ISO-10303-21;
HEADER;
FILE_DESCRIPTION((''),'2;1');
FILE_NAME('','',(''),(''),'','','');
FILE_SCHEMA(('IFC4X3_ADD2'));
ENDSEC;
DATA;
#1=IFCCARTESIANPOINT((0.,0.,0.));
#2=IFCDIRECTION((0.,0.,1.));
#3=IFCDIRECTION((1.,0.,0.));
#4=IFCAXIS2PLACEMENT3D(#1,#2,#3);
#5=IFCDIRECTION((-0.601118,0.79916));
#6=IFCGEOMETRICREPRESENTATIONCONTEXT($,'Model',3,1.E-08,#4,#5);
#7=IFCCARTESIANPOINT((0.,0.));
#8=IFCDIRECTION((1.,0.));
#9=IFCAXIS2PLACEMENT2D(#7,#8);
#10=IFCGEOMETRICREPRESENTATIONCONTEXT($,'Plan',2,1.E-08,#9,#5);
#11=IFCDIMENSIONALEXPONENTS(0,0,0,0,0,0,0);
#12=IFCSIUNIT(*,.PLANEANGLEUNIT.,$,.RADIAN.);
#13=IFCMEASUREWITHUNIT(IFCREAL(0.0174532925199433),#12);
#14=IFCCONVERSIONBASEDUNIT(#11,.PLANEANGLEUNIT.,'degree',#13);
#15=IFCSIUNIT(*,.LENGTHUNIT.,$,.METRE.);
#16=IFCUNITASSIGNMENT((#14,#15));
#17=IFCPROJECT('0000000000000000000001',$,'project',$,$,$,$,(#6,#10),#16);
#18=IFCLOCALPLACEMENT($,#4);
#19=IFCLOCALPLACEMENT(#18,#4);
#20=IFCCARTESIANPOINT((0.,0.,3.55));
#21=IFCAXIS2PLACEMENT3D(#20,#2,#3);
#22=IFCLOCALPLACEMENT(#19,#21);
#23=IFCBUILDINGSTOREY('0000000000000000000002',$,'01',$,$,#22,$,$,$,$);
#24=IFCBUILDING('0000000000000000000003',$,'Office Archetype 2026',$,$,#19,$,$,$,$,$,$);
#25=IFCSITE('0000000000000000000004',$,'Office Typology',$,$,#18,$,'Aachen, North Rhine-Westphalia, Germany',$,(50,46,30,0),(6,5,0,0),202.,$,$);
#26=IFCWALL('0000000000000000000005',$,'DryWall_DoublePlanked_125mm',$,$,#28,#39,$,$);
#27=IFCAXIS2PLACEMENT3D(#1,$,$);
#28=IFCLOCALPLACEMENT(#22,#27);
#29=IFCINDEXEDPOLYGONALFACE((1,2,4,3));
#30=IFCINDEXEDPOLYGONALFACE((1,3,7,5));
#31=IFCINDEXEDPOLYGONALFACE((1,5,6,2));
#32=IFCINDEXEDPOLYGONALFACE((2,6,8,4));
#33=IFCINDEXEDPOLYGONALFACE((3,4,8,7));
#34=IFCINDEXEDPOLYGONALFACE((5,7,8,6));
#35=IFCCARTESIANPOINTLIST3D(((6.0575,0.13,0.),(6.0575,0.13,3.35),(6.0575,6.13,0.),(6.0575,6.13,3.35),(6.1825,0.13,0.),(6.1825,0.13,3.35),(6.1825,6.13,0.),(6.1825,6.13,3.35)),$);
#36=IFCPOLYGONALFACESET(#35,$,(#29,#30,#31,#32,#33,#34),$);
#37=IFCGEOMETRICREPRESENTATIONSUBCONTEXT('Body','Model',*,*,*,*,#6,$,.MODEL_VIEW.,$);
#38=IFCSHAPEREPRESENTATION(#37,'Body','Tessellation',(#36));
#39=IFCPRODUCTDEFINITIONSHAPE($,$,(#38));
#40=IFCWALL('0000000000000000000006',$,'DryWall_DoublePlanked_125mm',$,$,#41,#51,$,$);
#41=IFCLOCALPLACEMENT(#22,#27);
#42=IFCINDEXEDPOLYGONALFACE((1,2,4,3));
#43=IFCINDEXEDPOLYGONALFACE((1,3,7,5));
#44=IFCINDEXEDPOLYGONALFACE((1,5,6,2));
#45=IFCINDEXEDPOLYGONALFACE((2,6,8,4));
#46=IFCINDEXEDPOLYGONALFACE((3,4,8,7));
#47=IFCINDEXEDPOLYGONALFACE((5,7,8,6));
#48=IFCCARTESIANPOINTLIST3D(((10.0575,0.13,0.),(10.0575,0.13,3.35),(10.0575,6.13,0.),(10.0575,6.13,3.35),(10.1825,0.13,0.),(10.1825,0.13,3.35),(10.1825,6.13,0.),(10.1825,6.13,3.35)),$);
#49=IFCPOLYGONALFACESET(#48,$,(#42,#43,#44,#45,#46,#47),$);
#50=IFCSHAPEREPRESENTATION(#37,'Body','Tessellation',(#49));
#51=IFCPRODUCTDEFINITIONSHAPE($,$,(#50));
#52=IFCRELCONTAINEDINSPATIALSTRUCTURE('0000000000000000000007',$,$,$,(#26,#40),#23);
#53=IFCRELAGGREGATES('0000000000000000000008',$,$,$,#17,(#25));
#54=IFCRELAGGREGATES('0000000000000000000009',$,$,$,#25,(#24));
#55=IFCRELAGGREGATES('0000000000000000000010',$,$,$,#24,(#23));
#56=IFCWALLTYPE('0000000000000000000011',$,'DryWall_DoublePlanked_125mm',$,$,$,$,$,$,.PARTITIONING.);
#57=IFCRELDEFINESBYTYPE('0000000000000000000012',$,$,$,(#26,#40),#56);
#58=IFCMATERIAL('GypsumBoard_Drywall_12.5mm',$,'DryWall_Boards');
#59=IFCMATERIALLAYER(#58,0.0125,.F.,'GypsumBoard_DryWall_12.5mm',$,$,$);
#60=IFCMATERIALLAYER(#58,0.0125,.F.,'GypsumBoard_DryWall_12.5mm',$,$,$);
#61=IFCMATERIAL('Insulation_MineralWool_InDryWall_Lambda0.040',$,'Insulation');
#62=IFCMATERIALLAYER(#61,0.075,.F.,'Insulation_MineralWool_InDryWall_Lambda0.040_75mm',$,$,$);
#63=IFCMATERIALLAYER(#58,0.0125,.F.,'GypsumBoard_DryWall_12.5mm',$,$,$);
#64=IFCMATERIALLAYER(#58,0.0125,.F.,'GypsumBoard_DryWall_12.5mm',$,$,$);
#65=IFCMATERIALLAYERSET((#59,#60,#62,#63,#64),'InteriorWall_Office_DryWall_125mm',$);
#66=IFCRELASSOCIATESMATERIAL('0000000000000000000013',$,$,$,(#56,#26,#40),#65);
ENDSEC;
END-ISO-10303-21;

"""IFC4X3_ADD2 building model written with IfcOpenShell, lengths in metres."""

from ifc_helpers import new_model, entity, si_unit, converted_unit, direction, frame, origin_with_axes, origin_2d_with_axis, place, context, subcontext, project, spatial, line, indexed_curve, outline, extrude, material, layer, layer_set, layer_usage, type_object, element, save


model = new_model("IFC4X3_ADD2")

# Units and contexts
model_context = context("Model", 3, precision=1e-08, world=origin_with_axes(), true_north=direction((-0.601118, 0.79916)))
plan_context = context("Plan", 2, precision=1e-08, world=origin_2d_with_axis(), true_north=direction((-0.601118, 0.79916)))
body_context = subcontext(model_context, "Body", "Model", "MODEL_VIEW")
ifc_project = project(units=[converted_unit("PLANEANGLEUNIT", "degree", entity("IfcReal", 0.0174532925199433), si_unit("PLANEANGLEUNIT", "RADIAN"), dimensions=[0, 0, 0, 0, 0, 0, 0]), si_unit("LENGTHUNIT", "METRE")], contexts=[model_context, plan_context])

# Site, building, storey
site_placement = place(None, origin_with_axes())
site = spatial("IfcSite", under=ifc_project, at=site_placement, Name="Office Typology", LongName="Aachen, North Rhine-Westphalia, Germany", RefLatitude=(50, 46, 30, 0), RefLongitude=(6, 5, 0, 0), RefElevation=202.0)
building_placement = place(site_placement, origin_with_axes())
building = spatial("IfcBuilding", under=site, at=building_placement, Name="Office Archetype 2026")
storey_placement = place(building_placement, frame((0.0, 0.0, 3.55), z_axis=(0.0, 0.0, 1.0), x_axis=(1.0, 0.0, 0.0)))
storey = spatial("IfcBuildingStorey", under=building, at=storey_placement, Name="01")

# Walls
ifc_material_1 = material(Name="GypsumBoard_Drywall_12.5mm", Category="DryWall_Boards")
ifc_layer_1 = layer(ifc_material_1, 0.0125, ventilated=False, Name="GypsumBoard_DryWall_12.5mm")
ifc_layer_2 = layer(ifc_material_1, 0.0125, ventilated=False, Name="GypsumBoard_DryWall_12.5mm")
ifc_material_2 = material(Name="Insulation_MineralWool_InDryWall_Lambda0.040", Category="Insulation")
ifc_layer_3 = layer(ifc_material_2, 0.075, ventilated=False, Name="Insulation_MineralWool_InDryWall_Lambda0.040_75mm")
ifc_layer_4 = layer(ifc_material_1, 0.0125, ventilated=False, Name="GypsumBoard_DryWall_12.5mm")
ifc_layer_5 = layer(ifc_material_1, 0.0125, ventilated=False, Name="GypsumBoard_DryWall_12.5mm")
ifc_layer_set_1 = layer_set([ifc_layer_1, ifc_layer_2, ifc_layer_3, ifc_layer_4, ifc_layer_5], Name="InteriorWall_Office_DryWall_125mm")
wall_type_1 = type_object("IfcWallType", Name="DryWall_DoublePlanked_125mm", PredefinedType="PARTITIONING", material=ifc_layer_set_1)
ifc_layer_usage_1 = layer_usage(ifc_layer_set_1, "AXIS2", "POSITIVE", 0.0)
wall_1_placement = place(storey_placement, frame((6.0575, 6.13, 0.0), z_axis=(0.0, 0.0, 1.0), x_axis=(0.0, -1.0, 0.0)))
element("IfcWall", 1, at=wall_1_placement, inside=storey, type_object=wall_type_1, material=ifc_layer_usage_1, Name="DryWall_DoublePlanked_125mm", context=body_context, shape_type="SweptSolid", body=[
    extrude(outline(indexed_curve([(0.0, 0.0), (0.0, 0.125), (6.0, 0.125), (6.0, 0.0)], segments=[line(1, 2, 3, 4, 1)])), origin_with_axes(), (0.0, 0.0, 1.0), 3.35),
])
ifc_layer_usage_2 = layer_usage(ifc_layer_set_1, "AXIS2", "POSITIVE", 0.0)
wall_2_placement = place(storey_placement, frame((10.0575, 6.13, 0.0), z_axis=(0.0, 0.0, 1.0), x_axis=(0.0, -1.0, 0.0)))
element("IfcWall", 2, at=wall_2_placement, inside=storey, type_object=wall_type_1, material=ifc_layer_usage_2, Name="DryWall_DoublePlanked_125mm", context=body_context, shape_type="SweptSolid", body=[
    extrude(outline(indexed_curve([(0.0, 0.0), (0.0, 0.125), (6.0, 0.125), (6.0, 0.0)], segments=[line(1, 2, 3, 4, 1)])), origin_with_axes(), (0.0, 0.0, 1.0), 3.35),
])

save(model, "model.ifc")
